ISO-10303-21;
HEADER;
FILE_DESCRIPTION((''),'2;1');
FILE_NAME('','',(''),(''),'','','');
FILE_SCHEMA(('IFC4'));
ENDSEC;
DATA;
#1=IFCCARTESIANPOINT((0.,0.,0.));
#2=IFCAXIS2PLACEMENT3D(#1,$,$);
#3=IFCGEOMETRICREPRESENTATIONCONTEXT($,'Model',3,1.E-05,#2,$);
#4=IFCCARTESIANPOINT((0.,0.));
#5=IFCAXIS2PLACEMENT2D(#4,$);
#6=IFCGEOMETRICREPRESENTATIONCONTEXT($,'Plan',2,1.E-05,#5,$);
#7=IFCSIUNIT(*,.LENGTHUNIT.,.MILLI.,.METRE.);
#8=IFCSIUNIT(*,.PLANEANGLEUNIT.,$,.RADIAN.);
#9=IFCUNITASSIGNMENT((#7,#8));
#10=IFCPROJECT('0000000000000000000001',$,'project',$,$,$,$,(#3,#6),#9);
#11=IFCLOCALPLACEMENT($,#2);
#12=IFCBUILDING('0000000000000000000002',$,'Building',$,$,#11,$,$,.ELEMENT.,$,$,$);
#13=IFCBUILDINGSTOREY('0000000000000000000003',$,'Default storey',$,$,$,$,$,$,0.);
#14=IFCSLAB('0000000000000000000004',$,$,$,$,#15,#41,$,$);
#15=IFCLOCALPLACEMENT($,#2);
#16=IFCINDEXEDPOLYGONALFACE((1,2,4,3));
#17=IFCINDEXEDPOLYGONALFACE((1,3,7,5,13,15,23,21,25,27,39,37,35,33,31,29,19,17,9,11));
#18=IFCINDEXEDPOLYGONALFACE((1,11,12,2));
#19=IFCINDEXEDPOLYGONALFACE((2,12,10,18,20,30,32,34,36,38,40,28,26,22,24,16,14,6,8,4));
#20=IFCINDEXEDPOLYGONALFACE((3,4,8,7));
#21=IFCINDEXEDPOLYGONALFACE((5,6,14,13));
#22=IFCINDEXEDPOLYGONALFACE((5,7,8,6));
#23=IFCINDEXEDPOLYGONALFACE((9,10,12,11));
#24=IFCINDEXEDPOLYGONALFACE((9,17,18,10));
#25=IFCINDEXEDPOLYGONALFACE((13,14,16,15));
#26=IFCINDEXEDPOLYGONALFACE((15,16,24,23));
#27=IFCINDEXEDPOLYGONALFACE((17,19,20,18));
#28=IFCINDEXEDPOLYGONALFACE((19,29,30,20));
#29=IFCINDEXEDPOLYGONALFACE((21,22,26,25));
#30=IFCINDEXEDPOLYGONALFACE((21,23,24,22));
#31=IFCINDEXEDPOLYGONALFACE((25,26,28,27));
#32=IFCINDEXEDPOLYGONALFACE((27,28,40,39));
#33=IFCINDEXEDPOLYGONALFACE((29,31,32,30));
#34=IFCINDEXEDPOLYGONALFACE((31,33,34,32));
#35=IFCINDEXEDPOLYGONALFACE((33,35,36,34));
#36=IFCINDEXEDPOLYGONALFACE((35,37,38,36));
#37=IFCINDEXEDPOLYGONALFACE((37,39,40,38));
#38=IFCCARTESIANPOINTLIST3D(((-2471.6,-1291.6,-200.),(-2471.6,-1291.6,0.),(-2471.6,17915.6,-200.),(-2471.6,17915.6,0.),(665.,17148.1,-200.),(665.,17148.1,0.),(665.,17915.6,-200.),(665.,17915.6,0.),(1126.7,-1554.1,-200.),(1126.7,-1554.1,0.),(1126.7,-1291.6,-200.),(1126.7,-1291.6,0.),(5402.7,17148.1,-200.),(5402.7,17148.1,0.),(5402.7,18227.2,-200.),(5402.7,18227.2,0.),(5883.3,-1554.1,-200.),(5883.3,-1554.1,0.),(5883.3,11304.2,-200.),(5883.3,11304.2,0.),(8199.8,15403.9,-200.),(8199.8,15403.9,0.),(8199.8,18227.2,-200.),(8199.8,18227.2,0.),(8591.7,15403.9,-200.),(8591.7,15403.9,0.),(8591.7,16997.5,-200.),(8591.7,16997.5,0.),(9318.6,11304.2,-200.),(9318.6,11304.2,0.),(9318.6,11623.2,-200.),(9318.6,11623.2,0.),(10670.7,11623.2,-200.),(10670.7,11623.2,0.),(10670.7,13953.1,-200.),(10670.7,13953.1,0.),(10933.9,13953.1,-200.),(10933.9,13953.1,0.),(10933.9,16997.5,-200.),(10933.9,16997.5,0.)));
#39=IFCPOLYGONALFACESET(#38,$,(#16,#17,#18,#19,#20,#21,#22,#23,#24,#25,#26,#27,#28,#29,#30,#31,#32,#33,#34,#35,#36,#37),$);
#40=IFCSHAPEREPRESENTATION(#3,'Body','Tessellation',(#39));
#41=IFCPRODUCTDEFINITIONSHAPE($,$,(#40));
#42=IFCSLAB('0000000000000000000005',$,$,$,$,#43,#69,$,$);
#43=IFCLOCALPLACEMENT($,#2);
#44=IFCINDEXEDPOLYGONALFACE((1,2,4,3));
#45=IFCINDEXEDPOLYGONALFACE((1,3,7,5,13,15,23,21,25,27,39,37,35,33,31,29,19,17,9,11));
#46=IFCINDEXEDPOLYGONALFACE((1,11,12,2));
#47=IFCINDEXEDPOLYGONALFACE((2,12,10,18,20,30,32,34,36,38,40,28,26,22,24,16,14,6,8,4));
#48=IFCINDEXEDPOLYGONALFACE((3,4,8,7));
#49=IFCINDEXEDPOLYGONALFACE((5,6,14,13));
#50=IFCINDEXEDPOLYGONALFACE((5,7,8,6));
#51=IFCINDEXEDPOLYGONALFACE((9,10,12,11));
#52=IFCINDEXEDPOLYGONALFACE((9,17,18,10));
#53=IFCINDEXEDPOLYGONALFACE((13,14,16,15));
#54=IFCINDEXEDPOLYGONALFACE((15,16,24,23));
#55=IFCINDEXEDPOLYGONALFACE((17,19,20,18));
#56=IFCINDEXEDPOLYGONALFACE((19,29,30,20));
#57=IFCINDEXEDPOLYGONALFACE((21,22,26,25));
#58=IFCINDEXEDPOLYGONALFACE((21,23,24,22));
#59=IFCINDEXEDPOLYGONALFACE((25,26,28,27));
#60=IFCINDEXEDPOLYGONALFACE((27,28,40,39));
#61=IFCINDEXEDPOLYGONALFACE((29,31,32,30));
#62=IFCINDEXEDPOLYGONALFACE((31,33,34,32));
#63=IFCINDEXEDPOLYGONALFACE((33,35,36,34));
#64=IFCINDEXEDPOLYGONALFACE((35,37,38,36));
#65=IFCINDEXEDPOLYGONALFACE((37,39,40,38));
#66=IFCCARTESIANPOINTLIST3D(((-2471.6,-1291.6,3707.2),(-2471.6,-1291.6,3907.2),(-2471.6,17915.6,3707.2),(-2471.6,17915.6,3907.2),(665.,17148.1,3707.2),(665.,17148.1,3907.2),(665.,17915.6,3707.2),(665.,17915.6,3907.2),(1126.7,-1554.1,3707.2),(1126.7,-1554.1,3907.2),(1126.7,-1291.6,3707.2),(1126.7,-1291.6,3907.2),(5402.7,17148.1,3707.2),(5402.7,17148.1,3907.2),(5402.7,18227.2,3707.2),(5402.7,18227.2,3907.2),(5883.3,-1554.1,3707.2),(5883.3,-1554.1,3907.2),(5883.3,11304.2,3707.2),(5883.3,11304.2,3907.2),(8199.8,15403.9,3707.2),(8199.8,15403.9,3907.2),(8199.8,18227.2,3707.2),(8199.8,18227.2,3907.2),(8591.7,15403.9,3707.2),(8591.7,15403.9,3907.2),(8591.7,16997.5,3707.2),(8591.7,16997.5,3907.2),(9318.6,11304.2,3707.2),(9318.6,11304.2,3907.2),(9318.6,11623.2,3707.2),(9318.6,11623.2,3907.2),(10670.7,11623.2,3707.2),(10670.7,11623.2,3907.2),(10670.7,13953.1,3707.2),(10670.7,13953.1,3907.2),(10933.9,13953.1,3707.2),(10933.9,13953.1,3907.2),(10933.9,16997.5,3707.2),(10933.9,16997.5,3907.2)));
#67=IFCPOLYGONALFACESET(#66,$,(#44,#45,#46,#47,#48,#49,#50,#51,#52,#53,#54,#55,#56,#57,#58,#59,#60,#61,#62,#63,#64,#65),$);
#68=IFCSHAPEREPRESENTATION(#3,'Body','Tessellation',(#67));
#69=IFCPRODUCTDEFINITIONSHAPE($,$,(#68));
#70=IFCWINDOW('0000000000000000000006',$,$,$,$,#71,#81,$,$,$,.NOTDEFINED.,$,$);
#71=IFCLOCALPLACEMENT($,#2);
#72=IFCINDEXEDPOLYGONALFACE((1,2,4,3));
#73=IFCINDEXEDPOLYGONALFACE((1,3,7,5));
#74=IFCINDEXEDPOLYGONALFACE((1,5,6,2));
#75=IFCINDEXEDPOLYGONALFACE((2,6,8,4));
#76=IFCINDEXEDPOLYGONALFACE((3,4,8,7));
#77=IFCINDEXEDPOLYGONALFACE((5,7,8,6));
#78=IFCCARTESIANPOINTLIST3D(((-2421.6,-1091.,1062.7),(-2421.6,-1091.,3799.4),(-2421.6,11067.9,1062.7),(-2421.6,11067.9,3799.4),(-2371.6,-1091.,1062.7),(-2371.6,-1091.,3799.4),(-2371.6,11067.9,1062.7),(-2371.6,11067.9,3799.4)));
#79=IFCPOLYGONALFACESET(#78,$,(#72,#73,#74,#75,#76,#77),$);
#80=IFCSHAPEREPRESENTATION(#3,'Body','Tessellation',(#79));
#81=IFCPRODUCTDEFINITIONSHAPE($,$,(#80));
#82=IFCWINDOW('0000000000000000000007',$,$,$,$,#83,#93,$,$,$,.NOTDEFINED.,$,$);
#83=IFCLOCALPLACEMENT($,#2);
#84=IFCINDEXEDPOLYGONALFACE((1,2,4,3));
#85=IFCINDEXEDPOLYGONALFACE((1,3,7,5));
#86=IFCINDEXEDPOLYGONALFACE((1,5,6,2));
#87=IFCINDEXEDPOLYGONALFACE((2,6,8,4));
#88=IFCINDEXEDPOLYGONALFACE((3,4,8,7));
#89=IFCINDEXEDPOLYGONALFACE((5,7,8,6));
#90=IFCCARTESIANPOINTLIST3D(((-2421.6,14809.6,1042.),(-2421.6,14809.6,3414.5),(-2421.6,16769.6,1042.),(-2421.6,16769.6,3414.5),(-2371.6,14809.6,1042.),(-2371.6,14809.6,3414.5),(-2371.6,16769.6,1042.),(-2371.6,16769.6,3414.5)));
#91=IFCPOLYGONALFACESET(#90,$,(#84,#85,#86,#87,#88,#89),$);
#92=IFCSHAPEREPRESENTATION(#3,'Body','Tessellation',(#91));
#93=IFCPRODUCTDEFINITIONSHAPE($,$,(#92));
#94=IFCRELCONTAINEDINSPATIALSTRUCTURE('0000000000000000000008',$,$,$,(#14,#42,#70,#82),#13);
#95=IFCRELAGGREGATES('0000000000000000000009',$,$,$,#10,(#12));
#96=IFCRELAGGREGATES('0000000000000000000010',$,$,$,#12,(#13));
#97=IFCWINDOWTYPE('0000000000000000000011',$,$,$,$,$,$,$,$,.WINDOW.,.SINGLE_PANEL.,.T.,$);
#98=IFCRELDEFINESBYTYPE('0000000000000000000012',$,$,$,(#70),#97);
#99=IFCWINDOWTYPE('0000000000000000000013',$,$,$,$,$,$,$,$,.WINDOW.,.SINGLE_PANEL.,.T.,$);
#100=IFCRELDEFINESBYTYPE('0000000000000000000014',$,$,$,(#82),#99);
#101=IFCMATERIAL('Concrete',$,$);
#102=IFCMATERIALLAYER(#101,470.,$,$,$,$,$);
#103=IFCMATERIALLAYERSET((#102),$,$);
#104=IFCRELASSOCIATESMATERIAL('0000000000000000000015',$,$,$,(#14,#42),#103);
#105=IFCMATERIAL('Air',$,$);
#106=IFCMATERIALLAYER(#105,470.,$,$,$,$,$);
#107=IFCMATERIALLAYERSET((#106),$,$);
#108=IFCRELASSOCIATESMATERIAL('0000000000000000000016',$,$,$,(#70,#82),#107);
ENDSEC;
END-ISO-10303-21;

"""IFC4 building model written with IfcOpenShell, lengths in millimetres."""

from ifc_helpers import new_model, si_unit, frame, origin, origin_2d, place, context, project, spatial, polyline, rectangle, outline, extrude, boolean, material, layer, layer_set, layer_usage, type_object, element, save


model = new_model("IFC4")

# Units and contexts
model_context = context("Model", 3, precision=1e-05, world=origin())
plan_context = context("Plan", 2, precision=1e-05, world=origin_2d())
ifc_project = project(units=[si_unit("LENGTHUNIT", "METRE", prefix="MILLI"), si_unit("PLANEANGLEUNIT", "RADIAN")], contexts=[model_context, plan_context])

# Building, storey
placement = place(None, origin())
building = spatial("IfcBuilding", under=ifc_project, at=placement, Name="Building", CompositionType="ELEMENT")
storey = spatial("IfcBuildingStorey", under=building, Name="Default storey", Elevation=0.0)

# Slabs
ifc_material_1 = material(Name="Concrete")
ifc_layer_1 = layer(ifc_material_1, 470.0)
ifc_layer_set_1 = layer_set([ifc_layer_1])
ifc_layer_usage_1 = layer_usage(ifc_layer_set_1, "AXIS3", "POSITIVE", 0.0)
element("IfcSlab", 1, at=placement, inside=storey, material=ifc_layer_usage_1, context=model_context, shape_type="SweptSolid", body=[
    extrude(outline(polyline([(8591.7, 16997.5), (8591.7, 15403.9), (8199.8, 15403.9), (8199.8, 18227.2), (5402.7, 18227.2), (5402.7, 17148.1), (665.0, 17148.1), (665.0, 17915.6), (-2471.6, 17915.6), (-2471.6, -1291.6), (1126.7, -1291.6), (1126.7, -1554.1), (5883.3, -1554.1), (5883.3, 11304.2), (9318.6, 11304.2), (9318.6, 11623.2), (10670.7, 11623.2), (10670.7, 13953.1), (10933.9, 13953.1), (10933.9, 16997.5), (8591.7, 16997.5)])), frame((0.0, 0.0, -200.0), z_axis=(0.0, 0.0, 1000.0), x_axis=(1000.0, 0.0, 0.0)), (0.0, 0.0, 1.0), 200.0),
])
element("IfcSlab", 2, at=placement, inside=storey, material=ifc_layer_usage_1, context=model_context, shape_type="SweptSolid", body=[
    extrude(outline(polyline([(8591.7, 16997.5), (8591.7, 15403.9), (8199.8, 15403.9), (8199.8, 18227.2), (5402.7, 18227.2), (5402.7, 17148.1), (665.0, 17148.1), (665.0, 17915.6), (-2471.6, 17915.6), (-2471.6, -1291.6), (1126.7, -1291.6), (1126.7, -1554.1), (5883.3, -1554.1), (5883.3, 11304.2), (9318.6, 11304.2), (9318.6, 11623.2), (10670.7, 11623.2), (10670.7, 13953.1), (10933.9, 13953.1), (10933.9, 16997.5), (8591.7, 16997.5)])), frame((0.0, 0.0, 3907.2), z_axis=(0.0, 0.0, 1000.0), x_axis=(1000.0, 0.0, 0.0)), (0.0, 0.0, -1.0), 200.0),
])

# Windows
ifc_material_2 = material(Name="Air")
ifc_layer_2 = layer(ifc_material_2, 470.0)
ifc_layer_set_2 = layer_set([ifc_layer_2])
ifc_layer_usage_2 = layer_usage(ifc_layer_set_2, "AXIS3", "POSITIVE", 0.0)
window_type_1 = type_object("IfcWindowType", ParameterTakesPrecedence=True, PartitioningType="SINGLE_PANEL", PredefinedType="WINDOW")
element("IfcWindow", 3, at=placement, inside=storey, type_object=window_type_1, material=ifc_layer_usage_2, PredefinedType="NOTDEFINED", context=model_context, shape_type="CSG", body=[
    boolean("INTERSECTION", extrude(rectangle(XDim=12158.9, YDim=50.0, at=origin_2d()), frame((-2396.6, 4988.4, 1062.7), z_axis=(0.0, 0.0, 1000.0), x_axis=(0.0, 12158.909678, 0.0)), (0.0, 0.0, 1.0), 2736.7), extrude(rectangle(XDim=12158.9, YDim=50.0, at=origin_2d()), frame((-2396.6, 4988.4, 1062.7), z_axis=(0.0, 0.0, 1000.0), x_axis=(0.0, 12158.909678, 0.0)), (0.0, 0.0, 1.0), 2736.7)),
])
window_type_2 = type_object("IfcWindowType", ParameterTakesPrecedence=True, PartitioningType="SINGLE_PANEL", PredefinedType="WINDOW")
element("IfcWindow", 4, at=placement, inside=storey, type_object=window_type_2, material=ifc_layer_usage_2, PredefinedType="NOTDEFINED", context=model_context, shape_type="CSG", body=[
    boolean("INTERSECTION", extrude(rectangle(XDim=1960.0, YDim=50.0, at=origin_2d()), frame((-2396.6, 15789.6, 1042.0), z_axis=(0.0, 0.0, 1000.0), x_axis=(0.0, 1960.000038, 0.0)), (0.0, 0.0, 1.0), 2372.5), extrude(rectangle(XDim=1960.0, YDim=50.0, at=origin_2d()), frame((-2396.6, 15789.6, 1042.0), z_axis=(0.0, 0.0, 1000.0), x_axis=(0.0, 1960.000038, 0.0)), (0.0, 0.0, 1.0), 2372.5)),
])

save(model, "model.ifc")
